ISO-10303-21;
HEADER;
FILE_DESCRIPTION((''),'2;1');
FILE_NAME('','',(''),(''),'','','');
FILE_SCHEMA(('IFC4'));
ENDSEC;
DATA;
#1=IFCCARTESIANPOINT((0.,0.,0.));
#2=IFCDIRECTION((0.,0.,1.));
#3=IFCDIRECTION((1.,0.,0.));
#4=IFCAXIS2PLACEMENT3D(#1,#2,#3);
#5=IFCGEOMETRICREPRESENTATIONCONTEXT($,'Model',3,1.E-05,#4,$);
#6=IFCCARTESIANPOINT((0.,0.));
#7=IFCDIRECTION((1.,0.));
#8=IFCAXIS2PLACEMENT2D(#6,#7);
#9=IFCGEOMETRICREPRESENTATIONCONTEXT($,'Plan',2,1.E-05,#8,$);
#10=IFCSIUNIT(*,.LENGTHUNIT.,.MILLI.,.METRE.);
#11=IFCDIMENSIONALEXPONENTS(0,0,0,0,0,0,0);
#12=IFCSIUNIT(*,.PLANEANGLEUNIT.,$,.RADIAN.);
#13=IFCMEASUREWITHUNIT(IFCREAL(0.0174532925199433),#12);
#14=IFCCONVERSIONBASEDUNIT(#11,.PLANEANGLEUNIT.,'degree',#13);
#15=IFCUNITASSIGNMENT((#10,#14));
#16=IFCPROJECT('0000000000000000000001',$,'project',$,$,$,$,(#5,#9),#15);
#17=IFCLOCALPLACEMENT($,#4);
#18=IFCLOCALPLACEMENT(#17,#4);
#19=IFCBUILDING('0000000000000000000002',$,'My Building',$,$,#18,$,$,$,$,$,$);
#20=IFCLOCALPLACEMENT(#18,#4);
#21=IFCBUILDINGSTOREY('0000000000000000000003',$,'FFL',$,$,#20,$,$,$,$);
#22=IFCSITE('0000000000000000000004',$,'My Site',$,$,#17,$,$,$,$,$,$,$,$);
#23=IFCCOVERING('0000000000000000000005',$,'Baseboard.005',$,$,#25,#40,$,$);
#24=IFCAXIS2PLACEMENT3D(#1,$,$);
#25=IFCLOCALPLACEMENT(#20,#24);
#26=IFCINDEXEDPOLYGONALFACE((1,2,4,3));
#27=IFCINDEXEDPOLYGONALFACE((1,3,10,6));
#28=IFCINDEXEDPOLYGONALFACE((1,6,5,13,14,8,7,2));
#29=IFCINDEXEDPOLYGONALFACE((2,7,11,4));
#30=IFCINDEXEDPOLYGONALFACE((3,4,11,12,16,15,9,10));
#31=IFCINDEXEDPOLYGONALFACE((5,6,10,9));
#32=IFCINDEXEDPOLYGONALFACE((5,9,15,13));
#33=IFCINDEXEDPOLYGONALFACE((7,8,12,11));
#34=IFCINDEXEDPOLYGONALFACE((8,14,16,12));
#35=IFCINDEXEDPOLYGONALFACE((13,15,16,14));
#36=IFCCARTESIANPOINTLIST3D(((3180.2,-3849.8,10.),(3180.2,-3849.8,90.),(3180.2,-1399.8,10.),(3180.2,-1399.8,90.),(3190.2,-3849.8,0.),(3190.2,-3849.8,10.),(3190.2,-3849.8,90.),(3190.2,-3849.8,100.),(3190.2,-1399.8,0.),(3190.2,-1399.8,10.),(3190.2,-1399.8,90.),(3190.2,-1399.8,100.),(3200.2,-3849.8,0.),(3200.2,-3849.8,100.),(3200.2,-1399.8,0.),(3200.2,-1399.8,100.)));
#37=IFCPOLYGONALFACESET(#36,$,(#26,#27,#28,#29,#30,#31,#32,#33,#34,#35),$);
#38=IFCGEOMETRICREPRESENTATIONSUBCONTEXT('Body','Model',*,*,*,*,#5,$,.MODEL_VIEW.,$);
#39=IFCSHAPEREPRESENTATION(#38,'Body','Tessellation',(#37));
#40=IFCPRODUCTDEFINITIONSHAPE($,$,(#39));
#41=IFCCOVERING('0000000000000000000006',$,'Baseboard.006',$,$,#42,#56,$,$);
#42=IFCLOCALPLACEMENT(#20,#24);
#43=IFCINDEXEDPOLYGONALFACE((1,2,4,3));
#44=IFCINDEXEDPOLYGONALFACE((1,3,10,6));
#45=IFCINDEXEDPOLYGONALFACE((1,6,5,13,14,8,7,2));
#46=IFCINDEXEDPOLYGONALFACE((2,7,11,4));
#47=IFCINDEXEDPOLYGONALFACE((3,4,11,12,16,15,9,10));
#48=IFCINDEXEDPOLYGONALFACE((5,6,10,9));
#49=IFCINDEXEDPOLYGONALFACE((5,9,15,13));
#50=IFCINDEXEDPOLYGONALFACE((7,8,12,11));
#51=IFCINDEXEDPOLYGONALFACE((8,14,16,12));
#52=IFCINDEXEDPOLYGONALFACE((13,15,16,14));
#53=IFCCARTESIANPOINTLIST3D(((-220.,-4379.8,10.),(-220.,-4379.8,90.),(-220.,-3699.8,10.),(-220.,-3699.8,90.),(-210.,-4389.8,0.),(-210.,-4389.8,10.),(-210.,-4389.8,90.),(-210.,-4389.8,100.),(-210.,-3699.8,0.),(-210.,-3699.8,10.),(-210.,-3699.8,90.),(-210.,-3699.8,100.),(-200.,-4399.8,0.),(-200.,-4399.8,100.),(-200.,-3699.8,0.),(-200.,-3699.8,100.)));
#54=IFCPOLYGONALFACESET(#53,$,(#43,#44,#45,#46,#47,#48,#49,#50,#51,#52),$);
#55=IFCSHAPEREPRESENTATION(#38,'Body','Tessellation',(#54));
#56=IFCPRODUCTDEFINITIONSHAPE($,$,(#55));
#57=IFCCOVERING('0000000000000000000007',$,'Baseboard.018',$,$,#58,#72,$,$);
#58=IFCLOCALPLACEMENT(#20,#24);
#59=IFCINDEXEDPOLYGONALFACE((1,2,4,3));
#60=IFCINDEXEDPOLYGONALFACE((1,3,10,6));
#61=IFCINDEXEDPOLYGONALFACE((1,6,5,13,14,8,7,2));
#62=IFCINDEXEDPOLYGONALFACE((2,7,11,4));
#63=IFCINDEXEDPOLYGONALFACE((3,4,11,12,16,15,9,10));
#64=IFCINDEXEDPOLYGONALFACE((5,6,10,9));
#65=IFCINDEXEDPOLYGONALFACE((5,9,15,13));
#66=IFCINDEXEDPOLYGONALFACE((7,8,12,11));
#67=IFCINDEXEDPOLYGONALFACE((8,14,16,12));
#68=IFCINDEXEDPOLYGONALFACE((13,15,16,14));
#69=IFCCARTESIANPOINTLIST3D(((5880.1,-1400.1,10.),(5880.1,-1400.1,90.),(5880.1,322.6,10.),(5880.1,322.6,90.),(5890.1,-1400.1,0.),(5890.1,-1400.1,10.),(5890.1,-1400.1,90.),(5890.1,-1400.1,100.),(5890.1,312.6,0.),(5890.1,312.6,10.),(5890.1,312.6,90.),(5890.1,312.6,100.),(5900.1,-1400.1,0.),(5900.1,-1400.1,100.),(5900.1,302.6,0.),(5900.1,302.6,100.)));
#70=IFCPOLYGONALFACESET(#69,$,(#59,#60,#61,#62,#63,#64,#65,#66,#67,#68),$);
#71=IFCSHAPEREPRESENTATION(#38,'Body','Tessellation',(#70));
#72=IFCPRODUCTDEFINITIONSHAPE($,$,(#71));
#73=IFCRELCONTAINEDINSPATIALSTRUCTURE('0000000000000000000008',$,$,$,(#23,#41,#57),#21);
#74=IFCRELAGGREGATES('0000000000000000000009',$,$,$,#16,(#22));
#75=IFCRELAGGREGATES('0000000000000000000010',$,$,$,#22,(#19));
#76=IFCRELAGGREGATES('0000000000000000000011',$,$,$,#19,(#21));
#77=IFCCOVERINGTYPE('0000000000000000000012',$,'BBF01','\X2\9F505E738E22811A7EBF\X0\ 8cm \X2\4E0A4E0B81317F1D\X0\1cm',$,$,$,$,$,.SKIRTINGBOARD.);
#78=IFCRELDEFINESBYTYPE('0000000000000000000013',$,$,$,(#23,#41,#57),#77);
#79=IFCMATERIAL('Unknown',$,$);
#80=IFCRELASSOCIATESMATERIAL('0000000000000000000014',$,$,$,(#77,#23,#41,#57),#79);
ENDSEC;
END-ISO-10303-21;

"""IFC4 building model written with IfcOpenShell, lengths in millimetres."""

from ifc_helpers import new_model, entity, si_unit, converted_unit, frame, origin_with_axes, origin_2d_with_axis, place, context, subcontext, project, spatial, indexed_curve, outline, extrude, clip, halfspace, material, material_profile, profile_set, profile_usage, type_object, element, save


model = new_model("IFC4")

# Units and contexts
model_context = context("Model", 3, precision=1e-05, world=origin_with_axes())
plan_context = context("Plan", 2, precision=1e-05, world=origin_2d_with_axis())
body_context_1 = subcontext(model_context, "Body", "Model", "MODEL_VIEW")
ifc_project = project(units=[si_unit("LENGTHUNIT", "METRE", prefix="MILLI"), converted_unit("PLANEANGLEUNIT", "degree", entity("IfcReal", 0.0174532925199433), si_unit("PLANEANGLEUNIT", "RADIAN"), dimensions=[0, 0, 0, 0, 0, 0, 0])], contexts=[model_context, plan_context])

# Site, building, storey
site_placement = place(None, origin_with_axes())
site = spatial("IfcSite", under=ifc_project, at=site_placement, Name="My Site")
building_placement = place(site_placement, origin_with_axes())
building = spatial("IfcBuilding", under=site, at=building_placement, Name="My Building")
storey_placement = place(building_placement, origin_with_axes())
storey = spatial("IfcBuildingStorey", under=building, at=storey_placement, Name="FFL")

# Coverings
ifc_material_1 = material(Name="Unknown")
ifc_material_profile = material_profile(ifc_material_1, outline(indexed_curve([(0.0, 100.0), (10.0, 100.0), (10.0, 90.0), (20.0, 90.0), (20.0, 10.0), (10.0, 10.0), (10.0, 0.0), (0.0, 0.0), (0.0, 100.0)])))
ifc_profile_set = profile_set([ifc_material_profile])
covering_type_1 = type_object("IfcCoveringType", Name="BBF01", Description="齐平踢脚线 8cm 上下脱缝1cm", PredefinedType="SKIRTINGBOARD", material=ifc_profile_set)
ifc_profile_usage_1 = profile_usage(ifc_profile_set, cardinal=5)
covering_1_placement = place(storey_placement, frame((3200.2, -3849.8, 0.0), z_axis=(0.0, 1.0, 0.0), x_axis=(-1.0, 0.0, 0.0)))
element("IfcCovering", 1, at=covering_1_placement, inside=storey, type_object=covering_type_1, material=ifc_profile_usage_1, Name="Baseboard.005", context=body_context_1, shape_type="SweptSolid", body=[
    extrude(outline(indexed_curve([(0.0, 100.0), (10.0, 100.0), (10.0, 90.0), (20.0, 90.0), (20.0, 10.0), (10.0, 10.0), (10.0, 0.0), (0.0, 0.0), (0.0, 100.0)])), origin_with_axes(), (0.0, 0.0, 1.0), 2450.0),
])
ifc_profile_usage_2 = profile_usage(ifc_profile_set, cardinal=5)
covering_2_placement = place(storey_placement, frame((-200.0, -4399.8, 0.0), z_axis=(0.0, 1.0, 0.0), x_axis=(-1.0, 0.0, 0.0)))
element("IfcCovering", 2, at=covering_2_placement, inside=storey, type_object=covering_type_1, material=ifc_profile_usage_2, Name="Baseboard.006", context=body_context_1, shape_type="Clipping", body=[
    clip(extrude(outline(indexed_curve([(0.0, 100.0), (10.0, 100.0), (10.0, 90.0), (20.0, 90.0), (20.0, 10.0), (10.0, 10.0), (10.0, 0.0), (0.0, 0.0), (0.0, 100.0)])), origin_with_axes(), (0.0, 0.0, 1.0), 700.0), halfspace(frame((0.0, 0.0, 0.0), z_axis=(0.707106, 0.0, -0.707107), x_axis=(0.0, -1.0, 0.0)), False)),
])
ifc_profile_usage_3 = profile_usage(ifc_profile_set, cardinal=5)
covering_3_placement = place(storey_placement, frame((5900.1, -1400.1, 0.0), z_axis=(0.0, 1.0, 0.0), x_axis=(-1.0, 0.0, 0.0)))
element("IfcCovering", 3, at=covering_3_placement, inside=storey, type_object=covering_type_1, material=ifc_profile_usage_3, Name="Baseboard.018", context=body_context_1, shape_type="Clipping", body=[
    clip(extrude(outline(indexed_curve([(0.0, 100.0), (10.0, 100.0), (10.0, 90.0), (20.0, 90.0), (20.0, 10.0), (10.0, 10.0), (10.0, 0.0), (0.0, 0.0), (0.0, 100.0)])), origin_with_axes(), (0.0, 0.0, 1.0), 1722.7), halfspace(frame((20.0, 0.0, 1722.7), z_axis=(-0.707107, 0.0, 0.707106), x_axis=(0.0, 1.0, 0.0)), False)),
])

save(model, "model.ifc")
